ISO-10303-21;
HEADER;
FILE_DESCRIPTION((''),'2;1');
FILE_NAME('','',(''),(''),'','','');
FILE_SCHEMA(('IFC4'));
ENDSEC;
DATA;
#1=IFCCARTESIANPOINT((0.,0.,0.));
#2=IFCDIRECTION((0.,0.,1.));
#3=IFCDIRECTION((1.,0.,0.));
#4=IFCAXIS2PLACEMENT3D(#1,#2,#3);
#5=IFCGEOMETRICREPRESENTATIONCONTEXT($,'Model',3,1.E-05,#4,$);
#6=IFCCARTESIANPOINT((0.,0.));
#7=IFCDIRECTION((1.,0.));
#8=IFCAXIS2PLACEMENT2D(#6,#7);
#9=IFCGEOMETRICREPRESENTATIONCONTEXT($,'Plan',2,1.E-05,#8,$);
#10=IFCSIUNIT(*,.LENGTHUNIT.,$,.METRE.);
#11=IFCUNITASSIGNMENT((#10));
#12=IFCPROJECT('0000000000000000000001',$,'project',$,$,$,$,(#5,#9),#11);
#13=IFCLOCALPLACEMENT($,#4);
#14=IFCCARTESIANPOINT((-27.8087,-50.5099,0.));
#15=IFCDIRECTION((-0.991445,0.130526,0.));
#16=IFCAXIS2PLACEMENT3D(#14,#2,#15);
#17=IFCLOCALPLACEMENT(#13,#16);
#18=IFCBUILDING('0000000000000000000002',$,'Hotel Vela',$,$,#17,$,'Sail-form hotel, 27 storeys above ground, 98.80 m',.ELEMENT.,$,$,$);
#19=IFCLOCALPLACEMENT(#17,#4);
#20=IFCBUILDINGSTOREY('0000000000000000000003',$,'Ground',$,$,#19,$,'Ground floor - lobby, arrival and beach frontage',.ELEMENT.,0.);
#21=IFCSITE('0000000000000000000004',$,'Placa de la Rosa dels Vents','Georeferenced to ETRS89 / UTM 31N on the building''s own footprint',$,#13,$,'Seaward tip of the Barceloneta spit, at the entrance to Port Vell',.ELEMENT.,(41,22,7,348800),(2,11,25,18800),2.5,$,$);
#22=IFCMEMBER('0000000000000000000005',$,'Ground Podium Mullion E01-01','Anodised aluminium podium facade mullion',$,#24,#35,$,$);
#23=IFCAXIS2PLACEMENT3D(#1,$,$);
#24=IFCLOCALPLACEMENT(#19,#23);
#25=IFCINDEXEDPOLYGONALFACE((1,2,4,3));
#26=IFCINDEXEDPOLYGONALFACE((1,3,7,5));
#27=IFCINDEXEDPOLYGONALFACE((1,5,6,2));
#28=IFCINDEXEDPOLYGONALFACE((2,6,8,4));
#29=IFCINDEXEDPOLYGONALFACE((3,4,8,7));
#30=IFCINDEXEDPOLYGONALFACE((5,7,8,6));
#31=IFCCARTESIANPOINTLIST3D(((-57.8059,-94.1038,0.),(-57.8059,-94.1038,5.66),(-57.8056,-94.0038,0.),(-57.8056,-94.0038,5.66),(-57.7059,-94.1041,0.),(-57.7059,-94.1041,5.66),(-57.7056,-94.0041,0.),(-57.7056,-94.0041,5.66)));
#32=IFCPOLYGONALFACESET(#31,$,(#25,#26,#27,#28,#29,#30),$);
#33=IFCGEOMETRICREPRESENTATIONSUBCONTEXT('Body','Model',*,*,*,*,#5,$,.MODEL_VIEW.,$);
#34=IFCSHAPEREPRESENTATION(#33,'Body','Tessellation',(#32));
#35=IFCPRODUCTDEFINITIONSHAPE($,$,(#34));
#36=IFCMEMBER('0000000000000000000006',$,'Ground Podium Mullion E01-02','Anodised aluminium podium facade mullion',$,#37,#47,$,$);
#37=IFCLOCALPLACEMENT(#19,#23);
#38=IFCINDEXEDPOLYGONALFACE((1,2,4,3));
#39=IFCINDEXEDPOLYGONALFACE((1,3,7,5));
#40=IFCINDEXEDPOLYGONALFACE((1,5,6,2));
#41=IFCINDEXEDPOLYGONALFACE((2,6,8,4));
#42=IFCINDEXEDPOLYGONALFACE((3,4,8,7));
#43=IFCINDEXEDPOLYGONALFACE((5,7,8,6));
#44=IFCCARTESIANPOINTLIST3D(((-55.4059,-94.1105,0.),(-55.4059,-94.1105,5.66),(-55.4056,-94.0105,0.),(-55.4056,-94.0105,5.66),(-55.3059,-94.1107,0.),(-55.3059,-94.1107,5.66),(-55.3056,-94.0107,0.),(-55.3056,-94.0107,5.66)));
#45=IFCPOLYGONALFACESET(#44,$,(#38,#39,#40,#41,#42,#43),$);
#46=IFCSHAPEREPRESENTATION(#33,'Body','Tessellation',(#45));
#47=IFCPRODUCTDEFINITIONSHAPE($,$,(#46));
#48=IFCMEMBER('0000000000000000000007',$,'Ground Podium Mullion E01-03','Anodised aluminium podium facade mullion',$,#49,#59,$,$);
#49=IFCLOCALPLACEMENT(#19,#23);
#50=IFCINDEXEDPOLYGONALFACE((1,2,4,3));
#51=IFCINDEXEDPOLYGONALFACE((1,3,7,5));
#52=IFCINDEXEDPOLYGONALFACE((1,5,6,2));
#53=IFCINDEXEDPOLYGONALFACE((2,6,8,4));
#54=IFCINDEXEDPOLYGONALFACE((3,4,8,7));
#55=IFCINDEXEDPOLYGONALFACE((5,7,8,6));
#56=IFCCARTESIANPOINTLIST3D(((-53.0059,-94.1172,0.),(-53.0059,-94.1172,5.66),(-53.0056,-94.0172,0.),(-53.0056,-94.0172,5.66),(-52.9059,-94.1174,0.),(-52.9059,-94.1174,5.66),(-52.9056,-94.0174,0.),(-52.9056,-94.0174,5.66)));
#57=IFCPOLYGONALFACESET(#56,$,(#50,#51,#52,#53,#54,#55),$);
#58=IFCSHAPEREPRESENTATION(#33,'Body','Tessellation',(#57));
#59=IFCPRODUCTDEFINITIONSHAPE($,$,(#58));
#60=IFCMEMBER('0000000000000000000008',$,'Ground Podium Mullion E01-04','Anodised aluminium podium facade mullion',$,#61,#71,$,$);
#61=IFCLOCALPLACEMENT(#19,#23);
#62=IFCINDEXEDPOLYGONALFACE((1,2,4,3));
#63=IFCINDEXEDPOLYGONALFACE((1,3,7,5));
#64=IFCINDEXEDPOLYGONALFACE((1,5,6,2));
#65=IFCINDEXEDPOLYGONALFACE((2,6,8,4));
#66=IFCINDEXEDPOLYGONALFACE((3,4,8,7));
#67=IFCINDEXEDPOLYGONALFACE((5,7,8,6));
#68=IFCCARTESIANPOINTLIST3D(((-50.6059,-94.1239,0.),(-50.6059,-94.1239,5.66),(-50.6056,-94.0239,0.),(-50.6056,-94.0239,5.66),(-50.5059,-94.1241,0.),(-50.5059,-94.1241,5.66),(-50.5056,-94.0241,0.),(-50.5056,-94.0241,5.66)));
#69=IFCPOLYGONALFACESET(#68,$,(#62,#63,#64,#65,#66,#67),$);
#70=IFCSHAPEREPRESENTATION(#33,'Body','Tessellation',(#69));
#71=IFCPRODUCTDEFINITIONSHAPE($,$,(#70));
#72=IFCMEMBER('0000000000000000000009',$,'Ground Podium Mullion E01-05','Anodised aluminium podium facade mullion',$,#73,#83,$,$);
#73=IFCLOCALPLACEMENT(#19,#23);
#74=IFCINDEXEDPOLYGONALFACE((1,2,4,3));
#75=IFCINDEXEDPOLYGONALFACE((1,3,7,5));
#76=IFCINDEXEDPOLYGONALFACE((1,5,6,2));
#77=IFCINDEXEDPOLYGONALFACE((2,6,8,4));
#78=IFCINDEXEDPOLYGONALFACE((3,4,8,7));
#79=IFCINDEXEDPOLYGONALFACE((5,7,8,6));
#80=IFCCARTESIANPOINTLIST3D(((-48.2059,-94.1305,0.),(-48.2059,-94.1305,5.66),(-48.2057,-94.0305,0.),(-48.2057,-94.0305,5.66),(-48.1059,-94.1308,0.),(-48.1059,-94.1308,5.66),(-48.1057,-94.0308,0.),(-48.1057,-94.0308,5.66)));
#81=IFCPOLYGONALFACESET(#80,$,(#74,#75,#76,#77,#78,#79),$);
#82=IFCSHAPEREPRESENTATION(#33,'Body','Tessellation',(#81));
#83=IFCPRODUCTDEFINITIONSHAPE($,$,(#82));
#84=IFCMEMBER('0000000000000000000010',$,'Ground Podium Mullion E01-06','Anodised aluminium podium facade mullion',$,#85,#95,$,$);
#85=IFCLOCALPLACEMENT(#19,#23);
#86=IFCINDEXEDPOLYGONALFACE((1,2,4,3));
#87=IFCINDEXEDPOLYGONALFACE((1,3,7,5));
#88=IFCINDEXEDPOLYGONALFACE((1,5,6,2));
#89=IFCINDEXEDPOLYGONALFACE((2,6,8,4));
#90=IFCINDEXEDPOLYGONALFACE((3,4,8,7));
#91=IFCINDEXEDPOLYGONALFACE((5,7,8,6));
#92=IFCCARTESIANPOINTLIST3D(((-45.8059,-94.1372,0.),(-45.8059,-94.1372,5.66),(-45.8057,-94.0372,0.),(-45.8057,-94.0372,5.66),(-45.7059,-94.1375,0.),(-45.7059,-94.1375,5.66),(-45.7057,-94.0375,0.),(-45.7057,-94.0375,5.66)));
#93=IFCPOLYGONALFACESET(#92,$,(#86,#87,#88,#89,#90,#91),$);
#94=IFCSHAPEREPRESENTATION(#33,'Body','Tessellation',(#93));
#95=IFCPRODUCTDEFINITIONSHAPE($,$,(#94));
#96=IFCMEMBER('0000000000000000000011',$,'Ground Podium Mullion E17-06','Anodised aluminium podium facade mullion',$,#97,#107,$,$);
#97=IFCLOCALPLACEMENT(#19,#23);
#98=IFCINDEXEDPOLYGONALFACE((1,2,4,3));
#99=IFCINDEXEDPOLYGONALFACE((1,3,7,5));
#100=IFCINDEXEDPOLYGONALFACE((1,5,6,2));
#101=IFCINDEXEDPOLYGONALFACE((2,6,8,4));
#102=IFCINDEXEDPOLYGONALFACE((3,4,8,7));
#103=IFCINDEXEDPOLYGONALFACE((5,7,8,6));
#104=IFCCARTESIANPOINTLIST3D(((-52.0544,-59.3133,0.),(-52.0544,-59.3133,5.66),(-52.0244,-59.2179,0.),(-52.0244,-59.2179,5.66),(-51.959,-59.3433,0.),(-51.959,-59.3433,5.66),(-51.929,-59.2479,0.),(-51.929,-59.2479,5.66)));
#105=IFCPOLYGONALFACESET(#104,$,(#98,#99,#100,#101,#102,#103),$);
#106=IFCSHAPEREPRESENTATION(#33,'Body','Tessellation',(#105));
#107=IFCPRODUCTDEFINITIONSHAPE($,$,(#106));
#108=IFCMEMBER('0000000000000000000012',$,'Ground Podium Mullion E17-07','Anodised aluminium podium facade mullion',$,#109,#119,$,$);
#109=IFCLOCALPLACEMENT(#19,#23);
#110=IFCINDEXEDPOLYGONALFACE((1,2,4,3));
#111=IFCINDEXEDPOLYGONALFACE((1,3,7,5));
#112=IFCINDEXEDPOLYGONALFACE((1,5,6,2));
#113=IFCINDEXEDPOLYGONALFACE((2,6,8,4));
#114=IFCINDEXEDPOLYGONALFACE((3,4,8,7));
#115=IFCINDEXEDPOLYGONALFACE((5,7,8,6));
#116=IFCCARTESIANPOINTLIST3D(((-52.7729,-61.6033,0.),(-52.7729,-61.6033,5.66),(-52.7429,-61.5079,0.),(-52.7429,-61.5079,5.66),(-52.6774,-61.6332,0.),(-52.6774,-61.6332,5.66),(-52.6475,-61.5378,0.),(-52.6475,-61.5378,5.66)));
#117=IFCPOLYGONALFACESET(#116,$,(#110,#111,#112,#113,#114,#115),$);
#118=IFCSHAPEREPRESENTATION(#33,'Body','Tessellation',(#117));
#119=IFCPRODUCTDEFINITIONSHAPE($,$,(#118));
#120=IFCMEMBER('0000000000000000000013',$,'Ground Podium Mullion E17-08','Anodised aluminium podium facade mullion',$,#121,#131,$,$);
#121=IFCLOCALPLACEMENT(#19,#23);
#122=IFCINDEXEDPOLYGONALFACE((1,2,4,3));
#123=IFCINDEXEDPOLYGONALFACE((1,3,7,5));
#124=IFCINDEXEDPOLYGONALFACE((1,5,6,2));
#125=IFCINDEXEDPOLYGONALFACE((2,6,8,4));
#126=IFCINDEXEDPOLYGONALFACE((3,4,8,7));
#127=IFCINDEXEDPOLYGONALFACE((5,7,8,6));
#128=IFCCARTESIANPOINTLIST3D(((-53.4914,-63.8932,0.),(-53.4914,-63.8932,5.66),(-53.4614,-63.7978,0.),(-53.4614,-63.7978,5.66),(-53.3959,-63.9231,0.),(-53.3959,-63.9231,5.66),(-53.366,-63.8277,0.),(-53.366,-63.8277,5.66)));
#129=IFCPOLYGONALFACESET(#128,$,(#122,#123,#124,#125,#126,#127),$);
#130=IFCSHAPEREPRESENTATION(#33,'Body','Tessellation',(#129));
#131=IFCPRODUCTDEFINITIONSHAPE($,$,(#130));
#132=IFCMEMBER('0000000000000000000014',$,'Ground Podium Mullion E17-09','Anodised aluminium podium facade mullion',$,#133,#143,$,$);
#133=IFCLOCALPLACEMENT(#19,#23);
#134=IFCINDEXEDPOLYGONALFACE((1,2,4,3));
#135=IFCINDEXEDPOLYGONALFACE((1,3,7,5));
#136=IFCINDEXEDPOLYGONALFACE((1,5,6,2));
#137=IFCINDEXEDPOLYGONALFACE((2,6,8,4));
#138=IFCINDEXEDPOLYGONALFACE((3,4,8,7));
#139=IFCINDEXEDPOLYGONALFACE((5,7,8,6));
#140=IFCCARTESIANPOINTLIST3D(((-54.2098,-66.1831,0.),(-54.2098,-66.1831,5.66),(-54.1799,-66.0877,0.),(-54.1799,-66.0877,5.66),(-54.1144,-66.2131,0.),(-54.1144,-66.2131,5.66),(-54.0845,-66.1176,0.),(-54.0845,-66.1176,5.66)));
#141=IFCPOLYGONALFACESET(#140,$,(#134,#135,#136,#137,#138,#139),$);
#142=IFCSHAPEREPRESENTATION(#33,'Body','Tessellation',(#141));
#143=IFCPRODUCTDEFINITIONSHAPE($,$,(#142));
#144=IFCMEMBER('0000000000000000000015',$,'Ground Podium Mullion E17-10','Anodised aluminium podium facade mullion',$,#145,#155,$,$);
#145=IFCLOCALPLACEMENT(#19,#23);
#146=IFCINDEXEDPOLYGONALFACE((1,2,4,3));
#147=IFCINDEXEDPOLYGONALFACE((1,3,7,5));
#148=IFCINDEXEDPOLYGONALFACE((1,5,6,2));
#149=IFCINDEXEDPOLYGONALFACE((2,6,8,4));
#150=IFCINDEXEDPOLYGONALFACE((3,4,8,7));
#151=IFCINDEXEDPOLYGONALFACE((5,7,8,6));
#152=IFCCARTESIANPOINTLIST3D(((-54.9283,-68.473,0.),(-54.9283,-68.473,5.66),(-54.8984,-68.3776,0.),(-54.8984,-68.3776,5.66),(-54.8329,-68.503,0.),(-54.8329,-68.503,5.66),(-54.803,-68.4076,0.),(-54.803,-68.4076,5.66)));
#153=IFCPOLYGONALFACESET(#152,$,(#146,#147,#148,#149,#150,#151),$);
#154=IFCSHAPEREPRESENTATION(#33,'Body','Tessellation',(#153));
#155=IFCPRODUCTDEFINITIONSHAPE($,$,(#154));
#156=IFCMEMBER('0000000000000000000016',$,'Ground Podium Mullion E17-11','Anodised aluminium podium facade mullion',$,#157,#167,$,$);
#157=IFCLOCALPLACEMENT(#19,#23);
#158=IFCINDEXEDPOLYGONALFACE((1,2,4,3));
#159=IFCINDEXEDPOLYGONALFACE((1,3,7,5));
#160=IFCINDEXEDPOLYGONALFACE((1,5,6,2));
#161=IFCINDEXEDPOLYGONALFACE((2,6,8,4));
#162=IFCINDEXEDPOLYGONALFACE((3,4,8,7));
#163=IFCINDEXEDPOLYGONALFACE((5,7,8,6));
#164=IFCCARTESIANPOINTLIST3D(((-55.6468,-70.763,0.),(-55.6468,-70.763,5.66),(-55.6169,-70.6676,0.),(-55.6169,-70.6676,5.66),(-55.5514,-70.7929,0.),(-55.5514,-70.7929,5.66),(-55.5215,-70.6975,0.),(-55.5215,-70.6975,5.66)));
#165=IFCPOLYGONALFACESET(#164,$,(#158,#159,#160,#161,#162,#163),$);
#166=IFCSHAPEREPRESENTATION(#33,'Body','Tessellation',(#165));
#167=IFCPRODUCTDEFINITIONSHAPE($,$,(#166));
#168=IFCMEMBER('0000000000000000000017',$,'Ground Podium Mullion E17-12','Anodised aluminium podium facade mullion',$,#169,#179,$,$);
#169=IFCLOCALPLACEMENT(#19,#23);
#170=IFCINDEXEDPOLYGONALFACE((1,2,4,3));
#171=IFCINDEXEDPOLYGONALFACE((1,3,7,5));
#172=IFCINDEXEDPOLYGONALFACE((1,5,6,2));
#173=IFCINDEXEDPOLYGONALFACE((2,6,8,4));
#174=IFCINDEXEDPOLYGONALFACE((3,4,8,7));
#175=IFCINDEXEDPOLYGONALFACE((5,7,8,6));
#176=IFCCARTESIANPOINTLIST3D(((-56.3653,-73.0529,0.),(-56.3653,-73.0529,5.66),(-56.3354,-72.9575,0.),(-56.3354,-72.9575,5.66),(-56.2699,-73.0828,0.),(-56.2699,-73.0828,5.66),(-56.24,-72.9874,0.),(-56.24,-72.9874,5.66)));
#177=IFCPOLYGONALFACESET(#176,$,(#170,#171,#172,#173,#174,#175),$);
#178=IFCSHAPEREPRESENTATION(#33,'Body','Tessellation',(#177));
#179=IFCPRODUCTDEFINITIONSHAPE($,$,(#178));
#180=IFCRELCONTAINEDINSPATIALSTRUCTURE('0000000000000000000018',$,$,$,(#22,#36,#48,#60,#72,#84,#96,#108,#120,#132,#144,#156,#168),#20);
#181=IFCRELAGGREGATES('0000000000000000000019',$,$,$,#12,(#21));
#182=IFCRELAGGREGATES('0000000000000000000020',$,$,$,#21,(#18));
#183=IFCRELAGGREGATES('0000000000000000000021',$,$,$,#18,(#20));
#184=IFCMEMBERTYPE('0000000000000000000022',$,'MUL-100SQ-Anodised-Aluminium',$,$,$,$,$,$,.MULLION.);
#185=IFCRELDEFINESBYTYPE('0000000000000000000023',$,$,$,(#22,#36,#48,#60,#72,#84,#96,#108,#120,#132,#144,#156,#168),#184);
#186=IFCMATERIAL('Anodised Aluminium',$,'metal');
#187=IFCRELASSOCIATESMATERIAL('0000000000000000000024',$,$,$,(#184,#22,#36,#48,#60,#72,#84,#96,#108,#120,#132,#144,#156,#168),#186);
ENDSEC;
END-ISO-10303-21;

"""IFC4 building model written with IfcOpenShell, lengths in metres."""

from ifc_helpers import new_model, si_unit, frame, origin_with_axes, origin_2d_with_axis, place, context, subcontext, project, spatial, line, indexed_curve, rectangle, outline, extrude, material, material_profile, profile_set, profile_usage, type_object, element, save


model = new_model("IFC4")

# Units and contexts
model_context = context("Model", 3, precision=1e-05, world=origin_with_axes())
plan_context = context("Plan", 2, precision=1e-05, world=origin_2d_with_axis())
body_context = subcontext(model_context, "Body", "Model", "MODEL_VIEW")
ifc_project = project(units=[si_unit("LENGTHUNIT", "METRE")], contexts=[model_context, plan_context])

# Site, building, storey
site_placement = place(None, origin_with_axes())
site = spatial("IfcSite", under=ifc_project, at=site_placement, Name="Placa de la Rosa dels Vents", Description="Georeferenced to ETRS89 / UTM 31N on the building's own footprint", LongName="Seaward tip of the Barceloneta spit, at the entrance to Port Vell", CompositionType="ELEMENT", RefLatitude=(41, 22, 7, 348800), RefLongitude=(2, 11, 25, 18800), RefElevation=2.5)
building_placement = place(site_placement, frame((-27.8087, -50.5099, 0.0), z_axis=(0.0, 0.0, 1.0), x_axis=(-0.991445, 0.130526, 0.0)))
building = spatial("IfcBuilding", under=site, at=building_placement, Name="Hotel Vela", LongName="Sail-form hotel, 27 storeys above ground, 98.80 m", CompositionType="ELEMENT")
storey_placement = place(building_placement, origin_with_axes())
storey = spatial("IfcBuildingStorey", under=building, at=storey_placement, Name="Ground", LongName="Ground floor - lobby, arrival and beach frontage", CompositionType="ELEMENT", Elevation=0.0)

# Members
ifc_material_1 = material(Name="Anodised Aluminium", Category="metal")
ifc_material_profile = material_profile(ifc_material_1, rectangle(XDim=0.1, YDim=0.1))
ifc_profile_set = profile_set([ifc_material_profile], Name="MUL-100SQ-Anodised-Aluminium")
ifc_profile_usage_1 = profile_usage(ifc_profile_set)
member_type = type_object("IfcMemberType", Name="MUL-100SQ-Anodised-Aluminium", PredefinedType="MULLION", material=ifc_profile_set)
member_1_placement = place(storey_placement, frame((-57.8059, -94.1038, 0.0), z_axis=(0.0, 0.0, 1.0), x_axis=(0.999996, -0.002789, 0.0)))
element("IfcMember", 1, at=member_1_placement, inside=storey, type_object=member_type, material=ifc_profile_usage_1, Name="Ground Podium Mullion E01-01", Description="Anodised aluminium podium facade mullion", context=body_context, shape_type="SweptSolid", body=[
    extrude(outline(indexed_curve([(0.0, 0.0), (0.1, 0.0), (0.1, 0.1), (0.0, 0.1)], segments=[line(1, 2, 3, 4, 1)])), origin_with_axes(), (0.0, 0.0, 1.0), 5.66),
])
ifc_profile_usage_2 = profile_usage(ifc_profile_set)
member_2_placement = place(storey_placement, frame((-55.4059, -94.1105, 0.0), z_axis=(0.0, 0.0, 1.0), x_axis=(0.999996, -0.002789, 0.0)))
element("IfcMember", 2, at=member_2_placement, inside=storey, type_object=member_type, material=ifc_profile_usage_2, Name="Ground Podium Mullion E01-02", Description="Anodised aluminium podium facade mullion", context=body_context, shape_type="SweptSolid", body=[
    extrude(outline(indexed_curve([(0.0, 0.0), (0.1, 0.0), (0.1, 0.1), (0.0, 0.1)], segments=[line(1, 2, 3, 4, 1)])), origin_with_axes(), (0.0, 0.0, 1.0), 5.66),
])
ifc_profile_usage_3 = profile_usage(ifc_profile_set)
member_3_placement = place(storey_placement, frame((-53.0059, -94.1172, 0.0), z_axis=(0.0, 0.0, 1.0), x_axis=(0.999996, -0.002789, 0.0)))
element("IfcMember", 3, at=member_3_placement, inside=storey, type_object=member_type, material=ifc_profile_usage_3, Name="Ground Podium Mullion E01-03", Description="Anodised aluminium podium facade mullion", context=body_context, shape_type="SweptSolid", body=[
    extrude(outline(indexed_curve([(0.0, 0.0), (0.1, 0.0), (0.1, 0.1), (0.0, 0.1)], segments=[line(1, 2, 3, 4, 1)])), origin_with_axes(), (0.0, 0.0, 1.0), 5.66),
])
ifc_profile_usage_4 = profile_usage(ifc_profile_set)
member_4_placement = place(storey_placement, frame((-50.6059, -94.1239, 0.0), z_axis=(0.0, 0.0, 1.0), x_axis=(0.999996, -0.002789, 0.0)))
element("IfcMember", 4, at=member_4_placement, inside=storey, type_object=member_type, material=ifc_profile_usage_4, Name="Ground Podium Mullion E01-04", Description="Anodised aluminium podium facade mullion", context=body_context, shape_type="SweptSolid", body=[
    extrude(outline(indexed_curve([(0.0, 0.0), (0.1, 0.0), (0.1, 0.1), (0.0, 0.1)], segments=[line(1, 2, 3, 4, 1)])), origin_with_axes(), (0.0, 0.0, 1.0), 5.66),
])
ifc_profile_usage_5 = profile_usage(ifc_profile_set)
member_5_placement = place(storey_placement, frame((-48.2059, -94.1305, 0.0), z_axis=(0.0, 0.0, 1.0), x_axis=(0.999996, -0.002789, 0.0)))
element("IfcMember", 5, at=member_5_placement, inside=storey, type_object=member_type, material=ifc_profile_usage_5, Name="Ground Podium Mullion E01-05", Description="Anodised aluminium podium facade mullion", context=body_context, shape_type="SweptSolid", body=[
    extrude(outline(indexed_curve([(0.0, 0.0), (0.1, 0.0), (0.1, 0.1), (0.0, 0.1)], segments=[line(1, 2, 3, 4, 1)])), origin_with_axes(), (0.0, 0.0, 1.0), 5.66),
])
ifc_profile_usage_6 = profile_usage(ifc_profile_set)
member_6_placement = place(storey_placement, frame((-45.8059, -94.1372, 0.0), z_axis=(0.0, 0.0, 1.0), x_axis=(0.999996, -0.002789, 0.0)))
element("IfcMember", 6, at=member_6_placement, inside=storey, type_object=member_type, material=ifc_profile_usage_6, Name="Ground Podium Mullion E01-06", Description="Anodised aluminium podium facade mullion", context=body_context, shape_type="SweptSolid", body=[
    extrude(outline(indexed_curve([(0.0, 0.0), (0.1, 0.0), (0.1, 0.1), (0.0, 0.1)], segments=[line(1, 2, 3, 4, 1)])), origin_with_axes(), (0.0, 0.0, 1.0), 5.66),
])
ifc_profile_usage_7 = profile_usage(ifc_profile_set)
member_7_placement = place(storey_placement, frame((-52.0244, -59.2179, 0.0), z_axis=(0.0, 0.0, 1.0), x_axis=(-0.299373, -0.954136, 0.0)))
element("IfcMember", 7, at=member_7_placement, inside=storey, type_object=member_type, material=ifc_profile_usage_7, Name="Ground Podium Mullion E17-06", Description="Anodised aluminium podium facade mullion", context=body_context, shape_type="SweptSolid", body=[
    extrude(outline(indexed_curve([(0.0, 0.0), (0.1, 0.0), (0.1, 0.1), (0.0, 0.1)], segments=[line(1, 2, 3, 4, 1)])), origin_with_axes(), (0.0, 0.0, 1.0), 5.66),
])
ifc_profile_usage_8 = profile_usage(ifc_profile_set)
member_8_placement = place(storey_placement, frame((-52.7429, -61.5079, 0.0), z_axis=(0.0, 0.0, 1.0), x_axis=(-0.299373, -0.954136, 0.0)))
element("IfcMember", 8, at=member_8_placement, inside=storey, type_object=member_type, material=ifc_profile_usage_8, Name="Ground Podium Mullion E17-07", Description="Anodised aluminium podium facade mullion", context=body_context, shape_type="SweptSolid", body=[
    extrude(outline(indexed_curve([(0.0, 0.0), (0.1, 0.0), (0.1, 0.1), (0.0, 0.1)], segments=[line(1, 2, 3, 4, 1)])), origin_with_axes(), (0.0, 0.0, 1.0), 5.66),
])
ifc_profile_usage_9 = profile_usage(ifc_profile_set)
member_9_placement = place(storey_placement, frame((-53.4614, -63.7978, 0.0), z_axis=(0.0, 0.0, 1.0), x_axis=(-0.299373, -0.954136, 0.0)))
element("IfcMember", 9, at=member_9_placement, inside=storey, type_object=member_type, material=ifc_profile_usage_9, Name="Ground Podium Mullion E17-08", Description="Anodised aluminium podium facade mullion", context=body_context, shape_type="SweptSolid", body=[
    extrude(outline(indexed_curve([(0.0, 0.0), (0.1, 0.0), (0.1, 0.1), (0.0, 0.1)], segments=[line(1, 2, 3, 4, 1)])), origin_with_axes(), (0.0, 0.0, 1.0), 5.66),
])
ifc_profile_usage_10 = profile_usage(ifc_profile_set)
member_10_placement = place(storey_placement, frame((-54.1799, -66.0877, 0.0), z_axis=(0.0, 0.0, 1.0), x_axis=(-0.299373, -0.954136, 0.0)))
element("IfcMember", 10, at=member_10_placement, inside=storey, type_object=member_type, material=ifc_profile_usage_10, Name="Ground Podium Mullion E17-09", Description="Anodised aluminium podium facade mullion", context=body_context, shape_type="SweptSolid", body=[
    extrude(outline(indexed_curve([(0.0, 0.0), (0.1, 0.0), (0.1, 0.1), (0.0, 0.1)], segments=[line(1, 2, 3, 4, 1)])), origin_with_axes(), (0.0, 0.0, 1.0), 5.66),
])
ifc_profile_usage_11 = profile_usage(ifc_profile_set)
member_11_placement = place(storey_placement, frame((-54.8984, -68.3776, 0.0), z_axis=(0.0, 0.0, 1.0), x_axis=(-0.299373, -0.954136, 0.0)))
element("IfcMember", 11, at=member_11_placement, inside=storey, type_object=member_type, material=ifc_profile_usage_11, Name="Ground Podium Mullion E17-10", Description="Anodised aluminium podium facade mullion", context=body_context, shape_type="SweptSolid", body=[
    extrude(outline(indexed_curve([(0.0, 0.0), (0.1, 0.0), (0.1, 0.1), (0.0, 0.1)], segments=[line(1, 2, 3, 4, 1)])), origin_with_axes(), (0.0, 0.0, 1.0), 5.66),
])
ifc_profile_usage_12 = profile_usage(ifc_profile_set)
member_12_placement = place(storey_placement, frame((-55.6169, -70.6676, 0.0), z_axis=(0.0, 0.0, 1.0), x_axis=(-0.299373, -0.954136, 0.0)))
element("IfcMember", 12, at=member_12_placement, inside=storey, type_object=member_type, material=ifc_profile_usage_12, Name="Ground Podium Mullion E17-11", Description="Anodised aluminium podium facade mullion", context=body_context, shape_type="SweptSolid", body=[
    extrude(outline(indexed_curve([(0.0, 0.0), (0.1, 0.0), (0.1, 0.1), (0.0, 0.1)], segments=[line(1, 2, 3, 4, 1)])), origin_with_axes(), (0.0, 0.0, 1.0), 5.66),
])
ifc_profile_usage_13 = profile_usage(ifc_profile_set)
member_13_placement = place(storey_placement, frame((-56.3354, -72.9575, 0.0), z_axis=(0.0, 0.0, 1.0), x_axis=(-0.299373, -0.954136, 0.0)))
element("IfcMember", 13, at=member_13_placement, inside=storey, type_object=member_type, material=ifc_profile_usage_13, Name="Ground Podium Mullion E17-12", Description="Anodised aluminium podium facade mullion", context=body_context, shape_type="SweptSolid", body=[
    extrude(outline(indexed_curve([(0.0, 0.0), (0.1, 0.0), (0.1, 0.1), (0.0, 0.1)], segments=[line(1, 2, 3, 4, 1)])), origin_with_axes(), (0.0, 0.0, 1.0), 5.66),
])

save(model, "model.ifc")
